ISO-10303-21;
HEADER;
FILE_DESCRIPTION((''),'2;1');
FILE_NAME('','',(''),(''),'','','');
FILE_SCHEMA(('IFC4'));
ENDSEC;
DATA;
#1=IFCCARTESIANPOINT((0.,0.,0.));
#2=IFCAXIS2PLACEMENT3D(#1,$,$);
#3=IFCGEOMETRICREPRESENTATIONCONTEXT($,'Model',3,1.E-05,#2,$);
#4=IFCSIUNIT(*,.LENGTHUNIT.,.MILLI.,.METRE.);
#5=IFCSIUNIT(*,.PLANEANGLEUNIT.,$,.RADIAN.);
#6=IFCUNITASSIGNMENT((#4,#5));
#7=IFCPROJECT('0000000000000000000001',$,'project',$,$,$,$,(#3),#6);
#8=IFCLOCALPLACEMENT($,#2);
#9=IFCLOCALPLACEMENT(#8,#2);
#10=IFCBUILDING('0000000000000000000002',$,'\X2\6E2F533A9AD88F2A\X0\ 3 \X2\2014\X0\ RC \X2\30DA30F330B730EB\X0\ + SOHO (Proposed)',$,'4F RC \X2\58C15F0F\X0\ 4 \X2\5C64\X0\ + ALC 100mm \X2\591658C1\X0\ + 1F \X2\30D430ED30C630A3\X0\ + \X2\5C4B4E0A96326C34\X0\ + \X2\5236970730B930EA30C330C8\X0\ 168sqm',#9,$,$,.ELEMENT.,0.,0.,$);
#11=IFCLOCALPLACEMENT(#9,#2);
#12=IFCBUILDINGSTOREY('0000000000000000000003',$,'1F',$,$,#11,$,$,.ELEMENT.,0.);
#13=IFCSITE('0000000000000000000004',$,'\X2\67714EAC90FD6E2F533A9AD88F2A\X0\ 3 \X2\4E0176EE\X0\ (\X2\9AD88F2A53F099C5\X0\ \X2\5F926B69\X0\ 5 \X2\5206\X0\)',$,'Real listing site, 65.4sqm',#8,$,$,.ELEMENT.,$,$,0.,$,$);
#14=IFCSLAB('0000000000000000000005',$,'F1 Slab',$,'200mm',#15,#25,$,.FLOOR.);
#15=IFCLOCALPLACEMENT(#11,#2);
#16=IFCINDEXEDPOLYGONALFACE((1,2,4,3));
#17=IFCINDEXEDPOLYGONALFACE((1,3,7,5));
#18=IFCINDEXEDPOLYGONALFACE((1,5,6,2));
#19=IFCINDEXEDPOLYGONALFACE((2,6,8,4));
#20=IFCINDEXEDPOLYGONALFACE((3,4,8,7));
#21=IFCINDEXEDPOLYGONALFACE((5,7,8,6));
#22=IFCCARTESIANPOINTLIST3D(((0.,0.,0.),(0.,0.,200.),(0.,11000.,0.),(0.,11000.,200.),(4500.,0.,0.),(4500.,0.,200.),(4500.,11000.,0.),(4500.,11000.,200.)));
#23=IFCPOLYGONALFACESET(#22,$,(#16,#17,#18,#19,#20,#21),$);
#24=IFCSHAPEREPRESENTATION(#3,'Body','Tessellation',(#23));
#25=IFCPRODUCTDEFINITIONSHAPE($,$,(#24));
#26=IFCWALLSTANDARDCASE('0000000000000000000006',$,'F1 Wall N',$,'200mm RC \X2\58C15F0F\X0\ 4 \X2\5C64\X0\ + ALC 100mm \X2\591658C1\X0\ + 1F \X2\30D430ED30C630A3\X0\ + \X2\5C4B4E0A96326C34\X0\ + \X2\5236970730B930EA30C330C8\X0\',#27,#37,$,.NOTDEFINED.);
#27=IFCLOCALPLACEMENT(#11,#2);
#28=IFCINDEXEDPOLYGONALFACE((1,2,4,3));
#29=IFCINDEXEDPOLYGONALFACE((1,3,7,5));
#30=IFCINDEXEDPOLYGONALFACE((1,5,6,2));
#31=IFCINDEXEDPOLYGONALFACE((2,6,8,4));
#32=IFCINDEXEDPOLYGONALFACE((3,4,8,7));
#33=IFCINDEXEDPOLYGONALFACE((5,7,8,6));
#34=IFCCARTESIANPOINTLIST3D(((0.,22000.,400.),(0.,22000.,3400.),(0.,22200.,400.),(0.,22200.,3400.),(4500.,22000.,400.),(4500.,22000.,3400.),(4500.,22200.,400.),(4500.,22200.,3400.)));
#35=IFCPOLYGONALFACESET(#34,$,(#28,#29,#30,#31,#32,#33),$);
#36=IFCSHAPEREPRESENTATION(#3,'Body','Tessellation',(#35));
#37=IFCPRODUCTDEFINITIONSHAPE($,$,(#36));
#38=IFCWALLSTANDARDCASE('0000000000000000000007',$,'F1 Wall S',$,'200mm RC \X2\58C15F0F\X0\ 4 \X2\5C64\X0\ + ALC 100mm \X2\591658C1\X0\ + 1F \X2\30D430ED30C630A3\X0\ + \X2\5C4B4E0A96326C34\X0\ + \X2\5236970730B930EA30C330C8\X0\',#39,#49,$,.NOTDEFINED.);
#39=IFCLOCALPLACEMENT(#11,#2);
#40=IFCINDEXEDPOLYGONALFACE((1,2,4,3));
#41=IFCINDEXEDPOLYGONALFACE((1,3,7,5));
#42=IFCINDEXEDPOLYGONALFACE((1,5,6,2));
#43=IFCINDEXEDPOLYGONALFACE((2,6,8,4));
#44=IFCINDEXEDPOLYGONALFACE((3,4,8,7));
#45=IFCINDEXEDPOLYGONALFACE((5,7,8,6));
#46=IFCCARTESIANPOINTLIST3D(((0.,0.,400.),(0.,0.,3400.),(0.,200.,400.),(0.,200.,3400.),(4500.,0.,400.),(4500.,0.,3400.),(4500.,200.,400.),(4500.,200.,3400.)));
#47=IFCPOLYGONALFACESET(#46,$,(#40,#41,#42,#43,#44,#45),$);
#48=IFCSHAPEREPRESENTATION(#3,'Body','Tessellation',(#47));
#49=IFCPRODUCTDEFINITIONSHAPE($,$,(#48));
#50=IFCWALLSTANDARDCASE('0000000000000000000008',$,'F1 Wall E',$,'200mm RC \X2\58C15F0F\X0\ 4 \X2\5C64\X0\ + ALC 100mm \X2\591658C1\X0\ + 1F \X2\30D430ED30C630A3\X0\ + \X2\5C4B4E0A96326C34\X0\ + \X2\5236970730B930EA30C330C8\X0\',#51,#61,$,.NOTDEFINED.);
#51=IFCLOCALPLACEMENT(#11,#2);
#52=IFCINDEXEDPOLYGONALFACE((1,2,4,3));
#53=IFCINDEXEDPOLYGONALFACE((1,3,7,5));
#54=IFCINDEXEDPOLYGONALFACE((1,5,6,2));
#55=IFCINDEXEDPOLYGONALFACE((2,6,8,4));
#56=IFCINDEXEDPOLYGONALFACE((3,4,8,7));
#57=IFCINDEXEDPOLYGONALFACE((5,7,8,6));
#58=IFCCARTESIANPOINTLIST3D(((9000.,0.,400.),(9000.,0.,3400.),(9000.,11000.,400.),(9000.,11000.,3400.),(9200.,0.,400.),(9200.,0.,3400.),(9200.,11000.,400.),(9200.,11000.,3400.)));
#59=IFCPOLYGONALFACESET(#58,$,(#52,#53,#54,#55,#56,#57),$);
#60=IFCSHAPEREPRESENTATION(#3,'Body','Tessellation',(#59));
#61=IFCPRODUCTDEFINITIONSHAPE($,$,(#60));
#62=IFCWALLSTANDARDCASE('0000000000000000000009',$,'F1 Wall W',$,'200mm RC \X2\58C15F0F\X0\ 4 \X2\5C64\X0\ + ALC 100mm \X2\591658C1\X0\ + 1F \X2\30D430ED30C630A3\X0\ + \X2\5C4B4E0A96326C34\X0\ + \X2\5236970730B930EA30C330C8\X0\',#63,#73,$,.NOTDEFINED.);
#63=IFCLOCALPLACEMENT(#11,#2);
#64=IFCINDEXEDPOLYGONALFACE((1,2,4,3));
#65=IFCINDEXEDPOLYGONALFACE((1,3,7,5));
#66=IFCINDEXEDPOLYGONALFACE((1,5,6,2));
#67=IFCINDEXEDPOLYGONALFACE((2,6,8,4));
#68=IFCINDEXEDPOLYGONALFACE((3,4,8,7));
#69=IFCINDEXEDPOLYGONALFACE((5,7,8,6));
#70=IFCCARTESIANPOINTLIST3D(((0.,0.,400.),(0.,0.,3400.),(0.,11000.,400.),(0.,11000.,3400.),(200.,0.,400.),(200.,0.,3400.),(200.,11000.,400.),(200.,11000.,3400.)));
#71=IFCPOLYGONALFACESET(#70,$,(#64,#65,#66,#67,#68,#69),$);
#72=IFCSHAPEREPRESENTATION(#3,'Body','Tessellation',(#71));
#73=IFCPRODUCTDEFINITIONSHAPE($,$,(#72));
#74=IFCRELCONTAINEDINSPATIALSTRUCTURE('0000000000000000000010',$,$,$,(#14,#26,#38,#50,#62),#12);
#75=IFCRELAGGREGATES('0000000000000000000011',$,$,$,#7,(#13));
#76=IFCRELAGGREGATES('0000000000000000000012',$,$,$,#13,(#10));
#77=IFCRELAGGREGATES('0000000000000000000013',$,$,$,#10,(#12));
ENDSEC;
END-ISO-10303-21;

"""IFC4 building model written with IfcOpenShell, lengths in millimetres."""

from ifc_helpers import new_model, si_unit, frame, frame_2d, origin, place, context, project, spatial, rectangle, extrude, element, save


model = new_model("IFC4")

# Units and contexts
model_context = context("Model", 3, precision=1e-05, world=origin())
ifc_project = project(units=[si_unit("LENGTHUNIT", "METRE", prefix="MILLI"), si_unit("PLANEANGLEUNIT", "RADIAN")], contexts=[model_context])

# Site, building, storey
site_placement = place(None, origin())
site = spatial("IfcSite", under=ifc_project, at=site_placement, Name="東京都港区高輪 3 丁目 (高輪台駅 徒歩 5 分)", ObjectType="Real listing site, 65.4sqm", CompositionType="ELEMENT", RefElevation=0.0)
building_placement = place(site_placement, origin())
building = spatial("IfcBuilding", under=site, at=building_placement, Name="港区高輪 3 — RC ペンシル + SOHO (Proposed)", ObjectType="4F RC 壁式 4 層 + ALC 100mm 外壁 + 1F ピロティ + 屋上防水 + 制震スリット 168sqm", CompositionType="ELEMENT", ElevationOfRefHeight=0.0, ElevationOfTerrain=0.0)
storey_placement = place(building_placement, origin())
storey = spatial("IfcBuildingStorey", under=building, at=storey_placement, Name="1F", CompositionType="ELEMENT", Elevation=0.0)

# Slab
slab_placement = place(storey_placement, origin())
element("IfcSlab", 1, at=slab_placement, inside=storey, Name="F1 Slab", ObjectType="200mm", PredefinedType="FLOOR", context=model_context, shape_type="SweptSolid", body=[
    extrude(rectangle(XDim=4500.0, YDim=11000.0, at=frame_2d((2250.0, 5500.0))), origin(), (0.0, 0.0, 1.0), 200.0),
])

# Walls
wall_1_placement = place(storey_placement, frame((0.0, 11000.0, 200.0)))
element("IfcWallStandardCase", 2, at=wall_1_placement, inside=storey, Name="F1 Wall N", ObjectType="200mm RC 壁式 4 層 + ALC 100mm 外壁 + 1F ピロティ + 屋上防水 + 制震スリット", PredefinedType="NOTDEFINED", context=model_context, shape_type="SweptSolid", body=[
    extrude(rectangle(XDim=4500.0, YDim=200.0, at=frame_2d((2250.0, 100.0))), frame((0.0, 11000.0, 200.0)), (0.0, 0.0, 1.0), 3000.0),
])
wall_2_placement = place(storey_placement, frame((0.0, 0.0, 200.0)))
element("IfcWallStandardCase", 3, at=wall_2_placement, inside=storey, Name="F1 Wall S", ObjectType="200mm RC 壁式 4 層 + ALC 100mm 外壁 + 1F ピロティ + 屋上防水 + 制震スリット", PredefinedType="NOTDEFINED", context=model_context, shape_type="SweptSolid", body=[
    extrude(rectangle(XDim=4500.0, YDim=200.0, at=frame_2d((2250.0, 100.0))), frame((0.0, 0.0, 200.0)), (0.0, 0.0, 1.0), 3000.0),
])
wall_3_placement = place(storey_placement, frame((4500.0, 0.0, 200.0)))
element("IfcWallStandardCase", 4, at=wall_3_placement, inside=storey, Name="F1 Wall E", ObjectType="200mm RC 壁式 4 層 + ALC 100mm 外壁 + 1F ピロティ + 屋上防水 + 制震スリット", PredefinedType="NOTDEFINED", context=model_context, shape_type="SweptSolid", body=[
    extrude(rectangle(XDim=200.0, YDim=11000.0, at=frame_2d((100.0, 5500.0))), frame((4500.0, 0.0, 200.0)), (0.0, 0.0, 1.0), 3000.0),
])
wall_4_placement = place(storey_placement, frame((0.0, 0.0, 200.0)))
element("IfcWallStandardCase", 5, at=wall_4_placement, inside=storey, Name="F1 Wall W", ObjectType="200mm RC 壁式 4 層 + ALC 100mm 外壁 + 1F ピロティ + 屋上防水 + 制震スリット", PredefinedType="NOTDEFINED", context=model_context, shape_type="SweptSolid", body=[
    extrude(rectangle(XDim=200.0, YDim=11000.0, at=frame_2d((100.0, 5500.0))), frame((0.0, 0.0, 200.0)), (0.0, 0.0, 1.0), 3000.0),
])

save(model, "model.ifc")
